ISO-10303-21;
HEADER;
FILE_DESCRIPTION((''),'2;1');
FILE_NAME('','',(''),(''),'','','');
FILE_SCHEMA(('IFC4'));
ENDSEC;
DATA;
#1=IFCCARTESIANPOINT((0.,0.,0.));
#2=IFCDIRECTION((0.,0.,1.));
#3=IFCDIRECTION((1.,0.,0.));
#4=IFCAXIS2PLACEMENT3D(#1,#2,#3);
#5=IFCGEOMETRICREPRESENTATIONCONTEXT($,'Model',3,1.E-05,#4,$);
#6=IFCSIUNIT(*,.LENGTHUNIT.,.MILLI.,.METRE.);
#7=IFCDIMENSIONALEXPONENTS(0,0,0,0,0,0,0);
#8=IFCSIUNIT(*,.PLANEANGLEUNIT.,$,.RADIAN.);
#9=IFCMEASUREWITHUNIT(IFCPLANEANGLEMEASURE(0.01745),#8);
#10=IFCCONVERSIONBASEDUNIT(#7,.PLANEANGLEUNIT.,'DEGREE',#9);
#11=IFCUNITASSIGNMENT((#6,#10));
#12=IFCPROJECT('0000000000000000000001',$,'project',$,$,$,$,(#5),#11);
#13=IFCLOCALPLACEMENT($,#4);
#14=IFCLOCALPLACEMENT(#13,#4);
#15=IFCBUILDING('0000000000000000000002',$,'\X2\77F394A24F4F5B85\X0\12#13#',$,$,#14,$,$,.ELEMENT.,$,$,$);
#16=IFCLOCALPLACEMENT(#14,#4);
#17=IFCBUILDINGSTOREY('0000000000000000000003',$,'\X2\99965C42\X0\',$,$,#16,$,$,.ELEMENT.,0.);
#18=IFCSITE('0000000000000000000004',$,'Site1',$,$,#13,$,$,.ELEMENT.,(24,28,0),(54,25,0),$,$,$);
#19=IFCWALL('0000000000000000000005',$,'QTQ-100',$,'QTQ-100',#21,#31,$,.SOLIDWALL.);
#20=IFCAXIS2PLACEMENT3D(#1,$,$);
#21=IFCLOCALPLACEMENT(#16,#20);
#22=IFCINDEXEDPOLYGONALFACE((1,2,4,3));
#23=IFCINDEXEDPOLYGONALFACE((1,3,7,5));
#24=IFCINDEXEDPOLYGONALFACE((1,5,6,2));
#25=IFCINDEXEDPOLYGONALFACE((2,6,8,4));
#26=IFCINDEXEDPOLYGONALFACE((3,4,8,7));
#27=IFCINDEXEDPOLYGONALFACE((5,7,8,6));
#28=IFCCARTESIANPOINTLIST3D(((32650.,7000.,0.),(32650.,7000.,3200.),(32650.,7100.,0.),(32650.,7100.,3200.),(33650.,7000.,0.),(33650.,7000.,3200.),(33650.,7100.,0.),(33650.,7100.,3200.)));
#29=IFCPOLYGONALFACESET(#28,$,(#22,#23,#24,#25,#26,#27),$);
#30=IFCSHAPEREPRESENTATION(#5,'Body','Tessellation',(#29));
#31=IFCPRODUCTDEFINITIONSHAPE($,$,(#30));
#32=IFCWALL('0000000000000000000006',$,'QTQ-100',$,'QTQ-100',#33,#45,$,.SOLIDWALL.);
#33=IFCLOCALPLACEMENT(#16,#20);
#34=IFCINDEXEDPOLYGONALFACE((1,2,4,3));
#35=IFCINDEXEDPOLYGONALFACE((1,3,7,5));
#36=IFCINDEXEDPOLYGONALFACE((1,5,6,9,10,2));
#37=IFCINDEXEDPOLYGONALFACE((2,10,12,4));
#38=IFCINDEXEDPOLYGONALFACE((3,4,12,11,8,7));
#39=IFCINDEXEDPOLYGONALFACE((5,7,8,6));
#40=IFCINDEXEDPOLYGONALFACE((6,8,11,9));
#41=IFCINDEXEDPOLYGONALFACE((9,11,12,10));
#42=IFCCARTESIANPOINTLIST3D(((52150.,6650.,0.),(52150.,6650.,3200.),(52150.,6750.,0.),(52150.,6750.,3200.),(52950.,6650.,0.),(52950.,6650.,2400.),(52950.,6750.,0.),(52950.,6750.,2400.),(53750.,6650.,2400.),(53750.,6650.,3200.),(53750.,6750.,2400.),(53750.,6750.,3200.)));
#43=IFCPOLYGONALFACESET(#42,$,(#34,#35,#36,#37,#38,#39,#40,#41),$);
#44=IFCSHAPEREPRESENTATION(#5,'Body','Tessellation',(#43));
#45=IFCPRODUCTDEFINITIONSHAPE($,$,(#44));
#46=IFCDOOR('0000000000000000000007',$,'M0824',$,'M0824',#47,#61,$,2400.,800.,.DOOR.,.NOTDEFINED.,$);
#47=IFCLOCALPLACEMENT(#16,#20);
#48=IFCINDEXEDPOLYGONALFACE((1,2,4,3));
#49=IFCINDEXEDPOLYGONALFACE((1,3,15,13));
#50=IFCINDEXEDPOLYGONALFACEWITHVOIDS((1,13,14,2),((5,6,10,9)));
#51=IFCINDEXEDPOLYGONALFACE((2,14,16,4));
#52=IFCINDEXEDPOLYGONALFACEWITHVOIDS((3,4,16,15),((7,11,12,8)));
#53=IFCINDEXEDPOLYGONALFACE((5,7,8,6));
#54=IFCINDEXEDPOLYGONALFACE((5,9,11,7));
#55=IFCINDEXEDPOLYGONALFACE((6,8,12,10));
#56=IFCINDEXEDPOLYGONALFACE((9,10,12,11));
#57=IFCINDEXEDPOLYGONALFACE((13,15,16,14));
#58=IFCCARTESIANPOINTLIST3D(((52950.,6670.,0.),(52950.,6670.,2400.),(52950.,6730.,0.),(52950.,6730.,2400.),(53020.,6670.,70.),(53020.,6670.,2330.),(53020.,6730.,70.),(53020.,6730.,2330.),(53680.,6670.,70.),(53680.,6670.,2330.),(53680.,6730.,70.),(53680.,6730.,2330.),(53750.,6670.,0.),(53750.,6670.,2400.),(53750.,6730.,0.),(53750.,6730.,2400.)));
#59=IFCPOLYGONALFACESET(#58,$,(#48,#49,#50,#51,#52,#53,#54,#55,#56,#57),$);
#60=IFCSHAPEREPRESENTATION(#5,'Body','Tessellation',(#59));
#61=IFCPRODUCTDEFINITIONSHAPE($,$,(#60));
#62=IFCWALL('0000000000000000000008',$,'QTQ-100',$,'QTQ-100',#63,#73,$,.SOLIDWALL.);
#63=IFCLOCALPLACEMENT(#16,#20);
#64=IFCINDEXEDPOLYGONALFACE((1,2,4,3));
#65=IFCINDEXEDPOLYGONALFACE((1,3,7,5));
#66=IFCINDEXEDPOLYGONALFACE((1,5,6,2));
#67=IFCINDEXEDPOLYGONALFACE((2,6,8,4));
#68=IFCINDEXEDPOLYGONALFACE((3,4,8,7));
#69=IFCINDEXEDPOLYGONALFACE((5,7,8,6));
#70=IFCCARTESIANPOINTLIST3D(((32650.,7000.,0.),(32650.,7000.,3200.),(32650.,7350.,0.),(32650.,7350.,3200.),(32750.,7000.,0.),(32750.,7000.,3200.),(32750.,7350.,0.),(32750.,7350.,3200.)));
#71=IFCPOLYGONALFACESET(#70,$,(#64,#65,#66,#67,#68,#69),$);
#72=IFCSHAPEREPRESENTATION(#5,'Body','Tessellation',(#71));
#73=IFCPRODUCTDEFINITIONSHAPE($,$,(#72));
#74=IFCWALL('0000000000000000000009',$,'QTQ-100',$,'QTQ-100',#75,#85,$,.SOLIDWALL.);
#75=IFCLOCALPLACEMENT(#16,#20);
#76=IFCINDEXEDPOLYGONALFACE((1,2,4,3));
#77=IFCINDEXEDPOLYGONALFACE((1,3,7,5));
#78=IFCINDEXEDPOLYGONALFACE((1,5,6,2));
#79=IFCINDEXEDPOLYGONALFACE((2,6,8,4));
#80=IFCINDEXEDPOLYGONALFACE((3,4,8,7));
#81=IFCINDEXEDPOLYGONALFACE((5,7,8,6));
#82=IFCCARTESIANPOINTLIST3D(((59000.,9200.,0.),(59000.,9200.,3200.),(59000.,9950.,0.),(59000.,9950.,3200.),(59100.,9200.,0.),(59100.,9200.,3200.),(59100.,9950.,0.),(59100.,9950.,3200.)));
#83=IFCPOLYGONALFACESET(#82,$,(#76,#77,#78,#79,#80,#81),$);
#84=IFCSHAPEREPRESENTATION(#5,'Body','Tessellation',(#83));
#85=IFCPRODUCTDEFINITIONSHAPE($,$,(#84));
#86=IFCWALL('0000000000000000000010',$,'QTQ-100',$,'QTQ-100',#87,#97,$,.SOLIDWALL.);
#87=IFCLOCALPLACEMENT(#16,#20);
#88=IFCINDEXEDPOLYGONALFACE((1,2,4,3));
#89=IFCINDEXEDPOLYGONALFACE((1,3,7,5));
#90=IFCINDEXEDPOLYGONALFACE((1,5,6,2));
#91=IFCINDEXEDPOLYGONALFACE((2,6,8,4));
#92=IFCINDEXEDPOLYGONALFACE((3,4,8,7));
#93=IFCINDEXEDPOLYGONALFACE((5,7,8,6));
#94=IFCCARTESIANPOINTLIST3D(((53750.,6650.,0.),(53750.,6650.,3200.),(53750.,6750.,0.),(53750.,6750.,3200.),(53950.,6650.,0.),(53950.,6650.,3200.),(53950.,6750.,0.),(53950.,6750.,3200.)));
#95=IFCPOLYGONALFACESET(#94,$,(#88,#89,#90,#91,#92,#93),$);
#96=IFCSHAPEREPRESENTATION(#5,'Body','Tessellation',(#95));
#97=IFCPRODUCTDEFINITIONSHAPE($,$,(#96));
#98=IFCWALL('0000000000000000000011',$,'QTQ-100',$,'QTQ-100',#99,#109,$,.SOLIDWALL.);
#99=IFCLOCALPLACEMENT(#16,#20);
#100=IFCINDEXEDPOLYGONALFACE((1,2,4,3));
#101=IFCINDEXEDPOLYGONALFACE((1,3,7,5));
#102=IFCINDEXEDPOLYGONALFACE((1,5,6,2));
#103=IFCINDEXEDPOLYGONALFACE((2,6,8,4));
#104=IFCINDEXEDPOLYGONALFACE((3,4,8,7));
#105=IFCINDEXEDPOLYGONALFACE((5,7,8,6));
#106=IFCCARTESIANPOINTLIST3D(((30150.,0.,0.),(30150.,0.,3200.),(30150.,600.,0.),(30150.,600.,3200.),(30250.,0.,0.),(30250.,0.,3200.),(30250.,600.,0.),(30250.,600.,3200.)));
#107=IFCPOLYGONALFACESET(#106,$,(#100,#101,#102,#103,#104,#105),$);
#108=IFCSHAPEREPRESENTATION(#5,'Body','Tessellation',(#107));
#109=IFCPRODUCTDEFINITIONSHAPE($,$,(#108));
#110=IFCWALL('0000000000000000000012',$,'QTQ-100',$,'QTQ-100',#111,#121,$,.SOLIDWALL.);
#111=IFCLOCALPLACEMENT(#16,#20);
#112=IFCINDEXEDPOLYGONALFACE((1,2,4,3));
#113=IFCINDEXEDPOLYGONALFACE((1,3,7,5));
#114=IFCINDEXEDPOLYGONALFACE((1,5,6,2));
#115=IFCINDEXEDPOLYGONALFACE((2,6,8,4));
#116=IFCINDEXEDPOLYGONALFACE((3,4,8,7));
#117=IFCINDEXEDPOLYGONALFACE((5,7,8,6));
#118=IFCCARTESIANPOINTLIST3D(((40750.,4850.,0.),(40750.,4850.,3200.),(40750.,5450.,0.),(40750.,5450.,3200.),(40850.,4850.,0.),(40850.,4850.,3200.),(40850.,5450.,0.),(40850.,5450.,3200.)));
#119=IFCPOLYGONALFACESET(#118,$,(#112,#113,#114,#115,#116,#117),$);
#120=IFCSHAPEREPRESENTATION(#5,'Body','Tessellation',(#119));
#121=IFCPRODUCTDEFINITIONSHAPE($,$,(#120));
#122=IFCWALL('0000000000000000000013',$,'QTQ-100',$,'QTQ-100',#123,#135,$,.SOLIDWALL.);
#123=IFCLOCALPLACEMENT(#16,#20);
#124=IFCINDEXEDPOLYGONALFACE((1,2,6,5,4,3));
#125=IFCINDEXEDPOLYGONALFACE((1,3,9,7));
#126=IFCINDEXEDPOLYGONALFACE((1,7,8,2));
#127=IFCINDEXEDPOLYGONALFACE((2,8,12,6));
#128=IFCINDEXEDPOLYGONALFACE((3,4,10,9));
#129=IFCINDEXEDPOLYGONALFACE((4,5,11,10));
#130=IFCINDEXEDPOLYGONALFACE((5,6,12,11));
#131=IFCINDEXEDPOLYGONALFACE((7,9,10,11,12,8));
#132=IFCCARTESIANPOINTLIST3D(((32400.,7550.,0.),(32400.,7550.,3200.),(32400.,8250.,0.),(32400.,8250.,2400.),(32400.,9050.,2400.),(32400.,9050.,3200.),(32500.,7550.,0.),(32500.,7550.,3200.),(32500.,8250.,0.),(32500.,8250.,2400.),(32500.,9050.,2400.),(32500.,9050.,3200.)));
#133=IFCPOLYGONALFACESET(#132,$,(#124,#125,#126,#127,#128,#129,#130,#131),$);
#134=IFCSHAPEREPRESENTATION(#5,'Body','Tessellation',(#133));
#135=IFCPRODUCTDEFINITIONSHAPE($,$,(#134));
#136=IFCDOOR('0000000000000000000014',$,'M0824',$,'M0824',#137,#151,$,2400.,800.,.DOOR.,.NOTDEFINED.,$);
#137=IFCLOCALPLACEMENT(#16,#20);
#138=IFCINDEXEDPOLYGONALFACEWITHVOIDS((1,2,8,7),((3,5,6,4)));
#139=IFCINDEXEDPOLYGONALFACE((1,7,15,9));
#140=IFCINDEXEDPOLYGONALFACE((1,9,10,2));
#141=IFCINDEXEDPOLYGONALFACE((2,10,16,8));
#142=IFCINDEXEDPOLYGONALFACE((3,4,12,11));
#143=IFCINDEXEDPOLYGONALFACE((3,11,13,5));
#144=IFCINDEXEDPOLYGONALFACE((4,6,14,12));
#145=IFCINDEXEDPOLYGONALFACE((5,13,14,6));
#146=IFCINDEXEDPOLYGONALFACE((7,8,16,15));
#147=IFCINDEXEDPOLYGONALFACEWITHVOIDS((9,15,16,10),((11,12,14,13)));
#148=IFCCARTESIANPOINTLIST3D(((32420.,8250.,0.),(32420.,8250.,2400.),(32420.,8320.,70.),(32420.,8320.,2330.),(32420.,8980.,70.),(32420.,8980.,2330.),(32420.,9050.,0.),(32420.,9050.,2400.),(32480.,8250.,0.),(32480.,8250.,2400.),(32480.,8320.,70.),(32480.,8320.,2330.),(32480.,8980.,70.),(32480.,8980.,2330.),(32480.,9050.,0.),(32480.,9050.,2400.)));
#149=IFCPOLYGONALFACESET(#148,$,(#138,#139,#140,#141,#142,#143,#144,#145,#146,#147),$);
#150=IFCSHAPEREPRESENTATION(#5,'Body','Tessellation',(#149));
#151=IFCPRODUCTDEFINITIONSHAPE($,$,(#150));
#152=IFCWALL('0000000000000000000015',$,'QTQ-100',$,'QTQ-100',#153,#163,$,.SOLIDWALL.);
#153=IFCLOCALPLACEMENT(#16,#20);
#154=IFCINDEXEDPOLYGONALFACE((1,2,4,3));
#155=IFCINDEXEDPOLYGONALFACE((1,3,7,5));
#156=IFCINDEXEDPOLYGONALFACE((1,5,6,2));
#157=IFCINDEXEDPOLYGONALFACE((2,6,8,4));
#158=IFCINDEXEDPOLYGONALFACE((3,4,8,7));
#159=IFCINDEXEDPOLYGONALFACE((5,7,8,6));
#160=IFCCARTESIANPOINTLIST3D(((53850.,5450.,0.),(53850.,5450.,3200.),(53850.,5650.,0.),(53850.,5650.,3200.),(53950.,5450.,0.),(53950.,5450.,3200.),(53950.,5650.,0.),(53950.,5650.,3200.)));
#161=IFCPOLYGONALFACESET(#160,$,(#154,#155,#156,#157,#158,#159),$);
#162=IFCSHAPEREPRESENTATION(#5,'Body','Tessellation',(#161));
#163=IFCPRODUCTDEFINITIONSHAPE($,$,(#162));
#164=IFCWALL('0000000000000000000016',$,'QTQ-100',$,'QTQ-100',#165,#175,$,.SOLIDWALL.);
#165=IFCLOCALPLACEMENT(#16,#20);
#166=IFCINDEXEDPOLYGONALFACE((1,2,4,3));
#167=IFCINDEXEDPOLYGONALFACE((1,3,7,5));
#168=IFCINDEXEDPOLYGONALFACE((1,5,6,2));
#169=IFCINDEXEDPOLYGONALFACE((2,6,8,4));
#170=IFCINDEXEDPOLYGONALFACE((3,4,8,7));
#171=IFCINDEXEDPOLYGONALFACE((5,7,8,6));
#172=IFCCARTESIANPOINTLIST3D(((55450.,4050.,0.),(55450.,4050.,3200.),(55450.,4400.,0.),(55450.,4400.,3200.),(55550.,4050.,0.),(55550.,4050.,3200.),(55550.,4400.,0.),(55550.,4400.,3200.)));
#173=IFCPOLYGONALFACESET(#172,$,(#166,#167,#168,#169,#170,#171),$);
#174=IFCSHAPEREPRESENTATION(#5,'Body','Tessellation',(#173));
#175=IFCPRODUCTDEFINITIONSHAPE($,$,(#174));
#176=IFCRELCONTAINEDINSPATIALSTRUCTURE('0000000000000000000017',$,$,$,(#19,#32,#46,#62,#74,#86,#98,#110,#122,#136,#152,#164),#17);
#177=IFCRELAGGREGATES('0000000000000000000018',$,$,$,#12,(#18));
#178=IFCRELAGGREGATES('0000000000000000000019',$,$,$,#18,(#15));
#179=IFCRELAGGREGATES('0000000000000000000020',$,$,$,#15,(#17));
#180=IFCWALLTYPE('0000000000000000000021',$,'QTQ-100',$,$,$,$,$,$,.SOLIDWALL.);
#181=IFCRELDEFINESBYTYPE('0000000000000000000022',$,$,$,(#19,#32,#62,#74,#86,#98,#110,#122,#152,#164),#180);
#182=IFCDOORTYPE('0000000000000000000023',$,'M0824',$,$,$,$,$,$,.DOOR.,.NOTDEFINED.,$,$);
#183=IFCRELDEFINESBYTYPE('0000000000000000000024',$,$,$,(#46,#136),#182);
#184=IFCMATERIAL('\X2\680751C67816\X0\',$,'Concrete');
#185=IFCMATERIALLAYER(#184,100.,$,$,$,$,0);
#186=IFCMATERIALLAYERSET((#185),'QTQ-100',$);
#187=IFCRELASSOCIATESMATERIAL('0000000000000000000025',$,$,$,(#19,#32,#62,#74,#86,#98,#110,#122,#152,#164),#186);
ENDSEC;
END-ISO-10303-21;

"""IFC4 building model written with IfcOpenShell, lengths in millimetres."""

from ifc_helpers import new_model, entity, si_unit, converted_unit, frame, origin_with_axes, place, context, project, spatial, polyline, outline, extrude, material, layer, layer_set, type_object, element, fill, save


model = new_model("IFC4")

# Units and contexts
model_context = context("Model", 3, precision=1e-05, world=origin_with_axes())
ifc_project = project(units=[si_unit("LENGTHUNIT", "METRE", prefix="MILLI"), converted_unit("PLANEANGLEUNIT", "DEGREE", entity("IfcPlaneAngleMeasure", 0.01745), si_unit("PLANEANGLEUNIT", "RADIAN"), dimensions=[0, 0, 0, 0, 0, 0, 0])], contexts=[model_context])

# Site, building, storey
site_placement = place(None, origin_with_axes())
site = spatial("IfcSite", under=ifc_project, at=site_placement, Name="Site1", CompositionType="ELEMENT", RefLatitude=(24, 28, 0), RefLongitude=(54, 25, 0))
building_placement = place(site_placement, origin_with_axes())
building = spatial("IfcBuilding", under=site, at=building_placement, Name="石钢住宅12#13#", CompositionType="ELEMENT")
storey_placement = place(building_placement, origin_with_axes())
storey = spatial("IfcBuildingStorey", under=building, at=storey_placement, Name="首层", CompositionType="ELEMENT", Elevation=0.0)

# Wall
ifc_material = material(Name="标准砖", Category="Concrete")
ifc_layer = layer(ifc_material, 100.0, Priority=0)
ifc_layer_set = layer_set([ifc_layer], Name="QTQ-100")
wall_type = type_object("IfcWallType", Name="QTQ-100", PredefinedType="SOLIDWALL")
wall_1_placement = place(storey_placement, origin_with_axes())
element("IfcWall", 1, at=wall_1_placement, inside=storey, type_object=wall_type, material=ifc_layer_set, Name="QTQ-100", ObjectType="QTQ-100", PredefinedType="SOLIDWALL", context=model_context, shape_type="SweptSolid", body=[
    extrude(outline(polyline([(0.0, 0.0), (3200.0, 0.0), (3200.0, 1000.0), (0.0, 1000.0), (0.0, 0.0)])), frame((33650.0, 7000.0, 3200.0), z_axis=(0.0, 1.0, 0.0), x_axis=(0.0, 0.0, -1.0)), (0.0, 0.0, 1.0), 100.0),
])

# Wall, opening, door
wall_2_placement = place(storey_placement, origin_with_axes())
wall_2 = element("IfcWall", 2, at=wall_2_placement, inside=storey, type_object=wall_type, material=ifc_layer_set, Name="QTQ-100", ObjectType="QTQ-100", PredefinedType="SOLIDWALL", context=model_context, shape_type="SweptSolid", body=[
    extrude(outline(polyline([(0.0, 0.0), (3200.0, 0.0), (3200.0, 1600.0), (0.0, 1600.0), (0.0, 0.0)])), frame((53750.0, 6650.0, 3200.0), z_axis=(0.0, 1.0, 0.0), x_axis=(0.0, 0.0, -1.0)), (0.0, 0.0, 1.0), 100.0),
])
opening_1_placement = place(storey_placement, origin_with_axes())
opening_1 = element("IfcOpeningElement", 3, at=opening_1_placement, cuts=wall_2, PredefinedType="OPENING", context=model_context, shape_type="SweptSolid", body=[
    extrude(outline(polyline([(0.0, 0.0), (800.0, 0.0), (800.0, 2400.0), (0.0, 2400.0), (0.0, 0.0)])), frame((53750.0, 5650.0, 0.0), z_axis=(0.0, 1.0, 0.0), x_axis=(-1.0, 0.0, 0.0)), (0.0, 0.0, 1.0), 2100.0),
])
door_type_1 = type_object("IfcDoorType", Name="M0824", OperationType="NOTDEFINED", PredefinedType="DOOR")
door_1_placement = place(storey_placement, origin_with_axes())
door_1 = element("IfcDoor", 4, at=door_1_placement, inside=storey, type_object=door_type_1, Name="M0824", ObjectType="M0824", OperationType="NOTDEFINED", OverallHeight=2400.0, OverallWidth=800.0, PredefinedType="DOOR", context=model_context, shape_type="SweptSolid", body=[
    extrude(outline(polyline([(-400.0, -1200.0), (400.0, -1200.0), (400.0, 1200.0), (-400.0, 1200.0), (-400.0, -1200.0)]), holes=[polyline([(-330.0, -1130.0), (-330.0, 1130.0), (330.0, 1130.0), (330.0, -1130.0), (-330.0, -1130.0)])]), frame((53350.0, 6670.0, 1200.0), z_axis=(0.0, 1.0, 0.0), x_axis=(-1.0, 0.0, 0.0)), (0.0, 0.0, 1.0), 60.0),
])
fill(opening_1, door_1)

# Walls
wall_3_placement = place(storey_placement, origin_with_axes())
element("IfcWall", 5, at=wall_3_placement, inside=storey, type_object=wall_type, material=ifc_layer_set, Name="QTQ-100", ObjectType="QTQ-100", PredefinedType="SOLIDWALL", context=model_context, shape_type="SweptSolid", body=[
    extrude(outline(polyline([(0.0, 0.0), (3200.0, 0.0), (3200.0, 350.0), (0.0, 350.0), (0.0, 0.0)])), frame((32750.0, 7350.0, 3200.0), z_axis=(-1.0, 0.0, 0.0), x_axis=(0.0, 0.0, -1.0)), (0.0, 0.0, 1.0), 100.0),
])
wall_4_placement = place(storey_placement, origin_with_axes())
element("IfcWall", 6, at=wall_4_placement, inside=storey, type_object=wall_type, material=ifc_layer_set, Name="QTQ-100", ObjectType="QTQ-100", PredefinedType="SOLIDWALL", context=model_context, shape_type="SweptSolid", body=[
    extrude(outline(polyline([(0.0, 0.0), (3200.0, 0.0), (3200.0, 750.0), (0.0, 750.0), (0.0, 0.0)])), frame((59100.0, 9950.0, 3200.0), z_axis=(-1.0, 0.0, 0.0), x_axis=(0.0, 0.0, -1.0)), (0.0, 0.0, 1.0), 100.0),
])
wall_5_placement = place(storey_placement, origin_with_axes())
element("IfcWall", 7, at=wall_5_placement, inside=storey, type_object=wall_type, material=ifc_layer_set, Name="QTQ-100", ObjectType="QTQ-100", PredefinedType="SOLIDWALL", context=model_context, shape_type="SweptSolid", body=[
    extrude(outline(polyline([(0.0, 0.0), (3200.0, 0.0), (3200.0, 200.0), (0.0, 200.0), (0.0, 0.0)])), frame((53950.0, 6650.0, 3200.0), z_axis=(0.0, 1.0, 0.0), x_axis=(0.0, 0.0, -1.0)), (0.0, 0.0, 1.0), 100.0),
])
wall_6_placement = place(storey_placement, origin_with_axes())
element("IfcWall", 8, at=wall_6_placement, inside=storey, type_object=wall_type, material=ifc_layer_set, Name="QTQ-100", ObjectType="QTQ-100", PredefinedType="SOLIDWALL", context=model_context, shape_type="SweptSolid", body=[
    extrude(outline(polyline([(0.0, 0.0), (3200.0, 0.0), (3200.0, 600.0), (0.0, 600.0), (0.0, 0.0)])), frame((30150.0, 0.0, 3200.0), z_axis=(1.0, 0.0, 0.0), x_axis=(0.0, 0.0, -1.0)), (0.0, 0.0, 1.0), 100.0),
])
wall_7_placement = place(storey_placement, origin_with_axes())
element("IfcWall", 9, at=wall_7_placement, inside=storey, type_object=wall_type, material=ifc_layer_set, Name="QTQ-100", ObjectType="QTQ-100", PredefinedType="SOLIDWALL", context=model_context, shape_type="SweptSolid", body=[
    extrude(outline(polyline([(0.0, 0.0), (3200.0, 0.0), (3200.0, 600.0), (0.0, 600.0), (0.0, 0.0)])), frame((40750.0, 4850.0, 3200.0), z_axis=(1.0, 0.0, 0.0), x_axis=(0.0, 0.0, -1.0)), (0.0, 0.0, 1.0), 100.0),
])

# Wall, opening, door
wall_8_placement = place(storey_placement, origin_with_axes())
wall_8 = element("IfcWall", 10, at=wall_8_placement, inside=storey, type_object=wall_type, material=ifc_layer_set, Name="QTQ-100", ObjectType="QTQ-100", PredefinedType="SOLIDWALL", context=model_context, shape_type="SweptSolid", body=[
    extrude(outline(polyline([(0.0, 0.0), (3200.0, 0.0), (3200.0, 1500.0), (0.0, 1500.0), (0.0, 0.0)])), frame((32500.0, 9050.0, 3200.0), z_axis=(-1.0, 0.0, 0.0), x_axis=(0.0, 0.0, -1.0)), (0.0, 0.0, 1.0), 100.0),
])
opening_2_placement = place(storey_placement, origin_with_axes())
opening_2 = element("IfcOpeningElement", 11, at=opening_2_placement, cuts=wall_8, PredefinedType="OPENING", context=model_context, shape_type="SweptSolid", body=[
    extrude(outline(polyline([(0.0, 0.0), (800.0, 0.0), (800.0, 2400.0), (0.0, 2400.0), (0.0, 0.0)])), frame((33500.0, 9050.0, 0.0), z_axis=(-1.0, 0.0, 0.0), x_axis=(0.0, -1.0, 0.0)), (0.0, 0.0, 1.0), 2100.0),
])
door_2_placement = place(storey_placement, origin_with_axes())
door_2 = element("IfcDoor", 12, at=door_2_placement, inside=storey, type_object=door_type_1, Name="M0824", ObjectType="M0824", OperationType="NOTDEFINED", OverallHeight=2400.0, OverallWidth=800.0, PredefinedType="DOOR", context=model_context, shape_type="SweptSolid", body=[
    extrude(outline(polyline([(-400.0, -1200.0), (400.0, -1200.0), (400.0, 1200.0), (-400.0, 1200.0), (-400.0, -1200.0)]), holes=[polyline([(-330.0, -1130.0), (-330.0, 1130.0), (330.0, 1130.0), (330.0, -1130.0), (-330.0, -1130.0)])]), frame((32480.0, 8650.0, 1200.0), z_axis=(-1.0, 0.0, 0.0), x_axis=(0.0, -1.0, 0.0)), (0.0, 0.0, 1.0), 60.0),
])
fill(opening_2, door_2)

# Walls
wall_9_placement = place(storey_placement, origin_with_axes())
element("IfcWall", 13, at=wall_9_placement, inside=storey, type_object=wall_type, material=ifc_layer_set, Name="QTQ-100", ObjectType="QTQ-100", PredefinedType="SOLIDWALL", context=model_context, shape_type="SweptSolid", body=[
    extrude(outline(polyline([(0.0, 0.0), (3200.0, 0.0), (3200.0, 200.0), (0.0, 200.0), (0.0, 0.0)])), frame((53950.0, 5650.0, 3200.0), z_axis=(-1.0, 0.0, 0.0), x_axis=(0.0, 0.0, -1.0)), (0.0, 0.0, 1.0), 100.0),
])
wall_10_placement = place(storey_placement, origin_with_axes())
element("IfcWall", 14, at=wall_10_placement, inside=storey, type_object=wall_type, material=ifc_layer_set, Name="QTQ-100", ObjectType="QTQ-100", PredefinedType="SOLIDWALL", context=model_context, shape_type="SweptSolid", body=[
    extrude(outline(polyline([(0.0, 0.0), (3200.0, 0.0), (3200.0, 350.0), (0.0, 350.0), (0.0, 0.0)])), frame((55450.0, 4050.0, 3200.0), z_axis=(1.0, 0.0, 0.0), x_axis=(0.0, 0.0, -1.0)), (0.0, 0.0, 1.0), 100.0),
])

save(model, "model.ifc")
